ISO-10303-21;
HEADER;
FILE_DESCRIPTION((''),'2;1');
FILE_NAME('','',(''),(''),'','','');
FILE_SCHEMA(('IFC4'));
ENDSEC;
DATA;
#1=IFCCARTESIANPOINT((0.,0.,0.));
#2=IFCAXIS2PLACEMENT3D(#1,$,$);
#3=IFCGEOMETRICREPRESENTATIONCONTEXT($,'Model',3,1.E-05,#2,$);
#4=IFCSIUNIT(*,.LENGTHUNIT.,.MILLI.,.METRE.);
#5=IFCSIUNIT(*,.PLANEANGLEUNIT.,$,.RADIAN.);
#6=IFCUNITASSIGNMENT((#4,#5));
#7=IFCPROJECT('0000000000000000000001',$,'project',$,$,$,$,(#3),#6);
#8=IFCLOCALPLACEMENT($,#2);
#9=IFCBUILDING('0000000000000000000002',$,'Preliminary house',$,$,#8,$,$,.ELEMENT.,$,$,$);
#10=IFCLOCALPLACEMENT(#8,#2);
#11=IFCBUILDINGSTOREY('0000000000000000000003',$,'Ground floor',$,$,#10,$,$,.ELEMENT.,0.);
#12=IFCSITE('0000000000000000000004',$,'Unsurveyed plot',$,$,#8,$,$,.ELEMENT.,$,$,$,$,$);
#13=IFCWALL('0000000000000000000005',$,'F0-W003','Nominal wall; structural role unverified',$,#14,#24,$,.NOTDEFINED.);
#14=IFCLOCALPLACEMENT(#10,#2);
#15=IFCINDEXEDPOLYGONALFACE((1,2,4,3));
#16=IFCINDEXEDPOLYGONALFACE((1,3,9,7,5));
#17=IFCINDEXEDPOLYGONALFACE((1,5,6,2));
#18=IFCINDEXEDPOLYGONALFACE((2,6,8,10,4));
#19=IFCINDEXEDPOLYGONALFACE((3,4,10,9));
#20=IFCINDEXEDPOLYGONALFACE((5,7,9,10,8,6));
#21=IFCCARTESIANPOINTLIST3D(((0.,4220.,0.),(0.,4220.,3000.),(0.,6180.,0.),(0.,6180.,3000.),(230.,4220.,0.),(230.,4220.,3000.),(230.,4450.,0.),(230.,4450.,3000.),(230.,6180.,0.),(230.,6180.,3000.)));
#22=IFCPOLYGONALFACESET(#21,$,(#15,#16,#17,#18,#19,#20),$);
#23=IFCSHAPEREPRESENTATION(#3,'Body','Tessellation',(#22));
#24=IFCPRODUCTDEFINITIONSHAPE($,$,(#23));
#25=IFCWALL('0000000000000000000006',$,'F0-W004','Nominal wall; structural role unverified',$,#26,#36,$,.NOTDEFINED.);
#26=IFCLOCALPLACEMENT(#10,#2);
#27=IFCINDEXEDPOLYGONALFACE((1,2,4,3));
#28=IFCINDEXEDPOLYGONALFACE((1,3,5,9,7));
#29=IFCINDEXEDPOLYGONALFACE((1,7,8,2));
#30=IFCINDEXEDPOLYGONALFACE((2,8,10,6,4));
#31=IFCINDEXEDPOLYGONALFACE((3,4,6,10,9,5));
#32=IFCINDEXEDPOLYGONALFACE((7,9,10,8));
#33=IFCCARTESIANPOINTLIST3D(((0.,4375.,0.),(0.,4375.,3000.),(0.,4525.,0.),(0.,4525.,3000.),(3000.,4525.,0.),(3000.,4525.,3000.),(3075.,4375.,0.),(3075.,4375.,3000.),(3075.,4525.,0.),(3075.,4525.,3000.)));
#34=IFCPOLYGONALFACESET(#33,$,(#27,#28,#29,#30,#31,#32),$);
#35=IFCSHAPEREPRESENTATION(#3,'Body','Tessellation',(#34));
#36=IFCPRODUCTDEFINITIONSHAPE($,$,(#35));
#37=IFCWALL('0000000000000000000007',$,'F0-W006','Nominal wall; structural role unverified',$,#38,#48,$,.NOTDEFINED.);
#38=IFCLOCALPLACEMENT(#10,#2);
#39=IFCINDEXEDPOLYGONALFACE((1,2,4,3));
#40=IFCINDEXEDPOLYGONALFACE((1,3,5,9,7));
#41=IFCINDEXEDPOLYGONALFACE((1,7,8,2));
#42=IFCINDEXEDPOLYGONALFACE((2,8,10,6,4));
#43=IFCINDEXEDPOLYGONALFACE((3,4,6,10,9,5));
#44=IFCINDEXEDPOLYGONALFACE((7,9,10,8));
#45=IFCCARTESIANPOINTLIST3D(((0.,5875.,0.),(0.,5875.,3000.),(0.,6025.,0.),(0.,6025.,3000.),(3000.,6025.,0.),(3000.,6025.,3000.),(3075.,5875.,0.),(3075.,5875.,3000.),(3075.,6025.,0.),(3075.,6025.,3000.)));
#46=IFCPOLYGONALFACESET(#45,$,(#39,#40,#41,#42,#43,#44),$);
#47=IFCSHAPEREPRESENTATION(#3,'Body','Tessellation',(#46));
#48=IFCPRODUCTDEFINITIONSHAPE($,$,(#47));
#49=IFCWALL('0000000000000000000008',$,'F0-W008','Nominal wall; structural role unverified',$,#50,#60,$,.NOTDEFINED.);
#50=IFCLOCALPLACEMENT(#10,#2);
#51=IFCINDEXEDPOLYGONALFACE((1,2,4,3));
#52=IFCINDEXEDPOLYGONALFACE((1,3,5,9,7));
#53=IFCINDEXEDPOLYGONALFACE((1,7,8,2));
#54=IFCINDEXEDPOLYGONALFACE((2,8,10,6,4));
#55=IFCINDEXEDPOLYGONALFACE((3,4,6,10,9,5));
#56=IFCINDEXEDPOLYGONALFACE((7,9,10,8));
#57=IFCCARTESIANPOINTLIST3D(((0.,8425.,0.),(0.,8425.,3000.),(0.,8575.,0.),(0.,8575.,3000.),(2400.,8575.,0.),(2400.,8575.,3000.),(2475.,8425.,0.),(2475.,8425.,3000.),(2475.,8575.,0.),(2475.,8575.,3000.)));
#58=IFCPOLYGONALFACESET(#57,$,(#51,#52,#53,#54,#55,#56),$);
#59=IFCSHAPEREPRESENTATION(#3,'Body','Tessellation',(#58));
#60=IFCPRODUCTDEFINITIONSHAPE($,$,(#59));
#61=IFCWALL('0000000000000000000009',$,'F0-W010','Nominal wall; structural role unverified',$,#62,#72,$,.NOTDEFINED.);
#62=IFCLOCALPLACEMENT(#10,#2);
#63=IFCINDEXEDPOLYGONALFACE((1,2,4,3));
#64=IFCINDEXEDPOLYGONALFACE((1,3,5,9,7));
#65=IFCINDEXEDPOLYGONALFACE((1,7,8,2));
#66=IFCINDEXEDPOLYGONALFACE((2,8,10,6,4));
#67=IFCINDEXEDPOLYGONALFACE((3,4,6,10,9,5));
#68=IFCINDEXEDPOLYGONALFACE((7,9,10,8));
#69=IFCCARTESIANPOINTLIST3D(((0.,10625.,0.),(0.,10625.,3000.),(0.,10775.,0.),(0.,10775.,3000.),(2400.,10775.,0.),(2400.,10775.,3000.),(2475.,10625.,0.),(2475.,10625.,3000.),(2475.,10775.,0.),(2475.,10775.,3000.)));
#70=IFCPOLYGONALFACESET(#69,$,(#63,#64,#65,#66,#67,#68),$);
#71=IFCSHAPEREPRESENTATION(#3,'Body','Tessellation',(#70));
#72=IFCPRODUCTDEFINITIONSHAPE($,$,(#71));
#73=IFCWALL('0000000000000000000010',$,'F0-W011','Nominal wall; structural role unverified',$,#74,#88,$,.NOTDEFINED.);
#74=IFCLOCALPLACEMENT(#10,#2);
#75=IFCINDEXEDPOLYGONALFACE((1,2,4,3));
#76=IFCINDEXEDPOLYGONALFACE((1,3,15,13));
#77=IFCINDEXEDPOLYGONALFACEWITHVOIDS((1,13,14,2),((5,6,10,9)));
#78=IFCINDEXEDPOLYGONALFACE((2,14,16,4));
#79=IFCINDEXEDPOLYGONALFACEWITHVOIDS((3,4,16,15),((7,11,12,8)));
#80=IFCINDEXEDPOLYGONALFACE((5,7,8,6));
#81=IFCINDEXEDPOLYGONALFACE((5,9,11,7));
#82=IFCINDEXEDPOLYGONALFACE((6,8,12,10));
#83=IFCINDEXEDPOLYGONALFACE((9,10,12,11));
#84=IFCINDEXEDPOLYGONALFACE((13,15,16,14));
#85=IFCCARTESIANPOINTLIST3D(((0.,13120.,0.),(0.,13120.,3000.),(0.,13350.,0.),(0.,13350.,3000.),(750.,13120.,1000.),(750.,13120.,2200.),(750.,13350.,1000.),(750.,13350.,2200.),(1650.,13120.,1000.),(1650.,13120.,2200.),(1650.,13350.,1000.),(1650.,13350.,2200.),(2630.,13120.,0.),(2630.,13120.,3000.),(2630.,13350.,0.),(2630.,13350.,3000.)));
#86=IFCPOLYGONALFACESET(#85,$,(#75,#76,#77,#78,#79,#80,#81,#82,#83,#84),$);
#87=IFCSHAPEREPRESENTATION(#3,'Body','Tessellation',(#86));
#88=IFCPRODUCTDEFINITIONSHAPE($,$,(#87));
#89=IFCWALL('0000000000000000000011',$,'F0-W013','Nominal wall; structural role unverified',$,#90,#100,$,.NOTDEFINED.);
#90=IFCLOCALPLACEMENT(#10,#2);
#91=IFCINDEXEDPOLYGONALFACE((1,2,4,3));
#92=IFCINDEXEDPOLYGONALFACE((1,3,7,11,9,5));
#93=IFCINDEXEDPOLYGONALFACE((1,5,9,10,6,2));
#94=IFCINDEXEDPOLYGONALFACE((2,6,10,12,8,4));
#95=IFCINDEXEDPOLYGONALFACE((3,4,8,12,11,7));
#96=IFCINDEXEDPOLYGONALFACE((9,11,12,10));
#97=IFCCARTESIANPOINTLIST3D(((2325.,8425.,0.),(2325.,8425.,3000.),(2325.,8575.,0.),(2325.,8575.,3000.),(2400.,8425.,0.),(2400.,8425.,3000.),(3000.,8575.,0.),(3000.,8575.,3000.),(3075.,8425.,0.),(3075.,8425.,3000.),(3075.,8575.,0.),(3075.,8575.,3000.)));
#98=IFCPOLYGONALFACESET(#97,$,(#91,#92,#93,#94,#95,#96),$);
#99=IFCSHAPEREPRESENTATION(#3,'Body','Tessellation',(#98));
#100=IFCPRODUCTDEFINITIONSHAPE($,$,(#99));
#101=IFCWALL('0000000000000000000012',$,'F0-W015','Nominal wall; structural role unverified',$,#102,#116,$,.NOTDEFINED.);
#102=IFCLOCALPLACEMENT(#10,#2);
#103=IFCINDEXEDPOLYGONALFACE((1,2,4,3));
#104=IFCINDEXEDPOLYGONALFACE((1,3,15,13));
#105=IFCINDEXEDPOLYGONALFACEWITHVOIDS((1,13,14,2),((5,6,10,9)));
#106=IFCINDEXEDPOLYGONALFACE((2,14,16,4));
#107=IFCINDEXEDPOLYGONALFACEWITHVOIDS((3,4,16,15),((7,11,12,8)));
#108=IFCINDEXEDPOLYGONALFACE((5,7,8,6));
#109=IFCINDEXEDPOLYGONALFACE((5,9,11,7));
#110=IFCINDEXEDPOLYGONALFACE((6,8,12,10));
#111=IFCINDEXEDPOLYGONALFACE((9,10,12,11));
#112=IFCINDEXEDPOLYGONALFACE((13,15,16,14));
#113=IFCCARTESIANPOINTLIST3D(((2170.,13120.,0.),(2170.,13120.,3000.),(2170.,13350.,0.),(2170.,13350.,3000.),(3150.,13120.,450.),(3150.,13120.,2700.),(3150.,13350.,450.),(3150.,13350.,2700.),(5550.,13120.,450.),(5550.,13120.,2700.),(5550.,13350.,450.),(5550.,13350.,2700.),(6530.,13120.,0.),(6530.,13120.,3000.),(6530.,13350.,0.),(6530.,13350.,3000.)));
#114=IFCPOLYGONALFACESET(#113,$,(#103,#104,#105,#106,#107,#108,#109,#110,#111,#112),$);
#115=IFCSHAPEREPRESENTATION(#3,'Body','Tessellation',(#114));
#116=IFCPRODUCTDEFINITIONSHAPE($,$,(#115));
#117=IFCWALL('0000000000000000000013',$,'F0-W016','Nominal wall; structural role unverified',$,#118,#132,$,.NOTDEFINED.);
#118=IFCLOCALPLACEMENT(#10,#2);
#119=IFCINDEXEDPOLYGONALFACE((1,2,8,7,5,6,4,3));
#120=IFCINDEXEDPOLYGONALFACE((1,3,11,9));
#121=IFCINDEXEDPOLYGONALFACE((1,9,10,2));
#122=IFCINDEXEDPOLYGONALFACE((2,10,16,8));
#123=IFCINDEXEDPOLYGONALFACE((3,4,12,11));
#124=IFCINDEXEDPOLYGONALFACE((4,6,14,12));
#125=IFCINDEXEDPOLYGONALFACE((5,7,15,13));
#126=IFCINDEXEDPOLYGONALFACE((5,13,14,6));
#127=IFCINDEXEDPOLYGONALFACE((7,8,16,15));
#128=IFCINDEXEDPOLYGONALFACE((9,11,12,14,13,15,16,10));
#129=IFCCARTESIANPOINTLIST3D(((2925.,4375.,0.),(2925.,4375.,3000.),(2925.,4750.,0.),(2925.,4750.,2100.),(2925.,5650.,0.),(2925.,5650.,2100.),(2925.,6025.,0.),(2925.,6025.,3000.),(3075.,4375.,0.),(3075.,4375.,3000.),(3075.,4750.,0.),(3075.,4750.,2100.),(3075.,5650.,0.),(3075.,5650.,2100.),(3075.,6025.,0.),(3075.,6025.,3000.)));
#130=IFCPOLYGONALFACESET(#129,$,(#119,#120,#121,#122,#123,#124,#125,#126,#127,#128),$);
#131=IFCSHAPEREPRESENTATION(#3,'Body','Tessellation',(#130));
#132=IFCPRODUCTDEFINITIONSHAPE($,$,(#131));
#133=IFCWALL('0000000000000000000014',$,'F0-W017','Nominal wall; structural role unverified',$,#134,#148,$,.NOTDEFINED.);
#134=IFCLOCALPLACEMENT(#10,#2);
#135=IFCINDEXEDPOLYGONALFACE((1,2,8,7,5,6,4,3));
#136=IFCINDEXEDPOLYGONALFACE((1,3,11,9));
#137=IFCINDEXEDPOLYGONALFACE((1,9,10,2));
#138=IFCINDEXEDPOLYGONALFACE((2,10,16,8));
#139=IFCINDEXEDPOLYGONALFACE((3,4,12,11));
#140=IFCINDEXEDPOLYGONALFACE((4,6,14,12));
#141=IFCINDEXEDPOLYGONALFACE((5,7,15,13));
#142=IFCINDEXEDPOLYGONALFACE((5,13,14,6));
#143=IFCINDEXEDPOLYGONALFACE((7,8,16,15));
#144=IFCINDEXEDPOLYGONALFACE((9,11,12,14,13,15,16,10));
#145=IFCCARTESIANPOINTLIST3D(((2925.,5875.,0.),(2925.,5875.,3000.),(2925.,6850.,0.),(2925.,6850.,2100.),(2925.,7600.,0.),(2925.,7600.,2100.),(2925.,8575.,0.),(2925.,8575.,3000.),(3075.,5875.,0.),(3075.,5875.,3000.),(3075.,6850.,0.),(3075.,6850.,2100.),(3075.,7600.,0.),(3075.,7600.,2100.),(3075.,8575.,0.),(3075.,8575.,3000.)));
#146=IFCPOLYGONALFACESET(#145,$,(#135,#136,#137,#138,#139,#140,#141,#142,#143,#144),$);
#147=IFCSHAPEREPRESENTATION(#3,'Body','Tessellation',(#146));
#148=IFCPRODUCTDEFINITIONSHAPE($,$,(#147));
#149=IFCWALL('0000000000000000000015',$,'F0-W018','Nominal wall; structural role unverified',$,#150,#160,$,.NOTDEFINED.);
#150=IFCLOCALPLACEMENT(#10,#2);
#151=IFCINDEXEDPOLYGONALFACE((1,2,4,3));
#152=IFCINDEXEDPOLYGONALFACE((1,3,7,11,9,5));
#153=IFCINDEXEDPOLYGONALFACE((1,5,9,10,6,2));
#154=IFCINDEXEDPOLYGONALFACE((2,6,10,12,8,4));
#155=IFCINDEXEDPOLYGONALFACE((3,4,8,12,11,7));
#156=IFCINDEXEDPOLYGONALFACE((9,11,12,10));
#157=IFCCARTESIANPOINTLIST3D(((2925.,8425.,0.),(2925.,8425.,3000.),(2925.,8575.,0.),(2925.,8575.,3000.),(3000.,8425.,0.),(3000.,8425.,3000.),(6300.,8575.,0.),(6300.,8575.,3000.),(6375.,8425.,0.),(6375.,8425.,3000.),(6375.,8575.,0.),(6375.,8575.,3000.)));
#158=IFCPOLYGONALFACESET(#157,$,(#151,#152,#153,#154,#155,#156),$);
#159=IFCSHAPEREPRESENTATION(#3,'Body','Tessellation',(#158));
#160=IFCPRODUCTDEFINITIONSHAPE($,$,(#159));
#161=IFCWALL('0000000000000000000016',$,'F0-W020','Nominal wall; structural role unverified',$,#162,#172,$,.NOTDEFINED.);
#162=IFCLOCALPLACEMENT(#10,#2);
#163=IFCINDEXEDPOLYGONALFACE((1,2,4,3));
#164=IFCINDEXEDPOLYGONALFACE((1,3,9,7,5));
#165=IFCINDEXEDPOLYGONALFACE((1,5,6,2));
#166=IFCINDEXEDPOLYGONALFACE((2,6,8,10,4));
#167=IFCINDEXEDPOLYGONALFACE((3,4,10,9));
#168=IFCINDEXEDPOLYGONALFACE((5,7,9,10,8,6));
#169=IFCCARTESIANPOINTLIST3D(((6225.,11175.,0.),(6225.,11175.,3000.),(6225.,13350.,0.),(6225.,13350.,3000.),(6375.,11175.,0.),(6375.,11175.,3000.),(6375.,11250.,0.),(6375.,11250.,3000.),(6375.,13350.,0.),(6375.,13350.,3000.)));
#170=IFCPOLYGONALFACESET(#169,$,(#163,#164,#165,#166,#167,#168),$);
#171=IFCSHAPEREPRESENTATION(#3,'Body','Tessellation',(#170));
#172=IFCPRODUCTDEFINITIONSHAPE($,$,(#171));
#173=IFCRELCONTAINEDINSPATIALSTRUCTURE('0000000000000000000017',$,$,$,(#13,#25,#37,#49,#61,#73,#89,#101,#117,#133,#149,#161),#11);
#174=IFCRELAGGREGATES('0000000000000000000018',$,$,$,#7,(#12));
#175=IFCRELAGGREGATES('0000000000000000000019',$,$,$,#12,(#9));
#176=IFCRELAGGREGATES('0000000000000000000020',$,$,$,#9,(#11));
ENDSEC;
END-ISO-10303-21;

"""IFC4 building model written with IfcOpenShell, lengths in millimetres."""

from ifc_helpers import new_model, si_unit, frame, origin, place, context, project, spatial, polyline, outline, extrude, element, save


model = new_model("IFC4")

# Units and contexts
model_context = context("Model", 3, precision=1e-05, world=origin())
ifc_project = project(units=[si_unit("LENGTHUNIT", "METRE", prefix="MILLI"), si_unit("PLANEANGLEUNIT", "RADIAN")], contexts=[model_context])

# Site, building, storey
placement_1 = place(None, origin())
site = spatial("IfcSite", under=ifc_project, at=placement_1, Name="Unsurveyed plot", CompositionType="ELEMENT")
building = spatial("IfcBuilding", under=site, at=placement_1, Name="Preliminary house", CompositionType="ELEMENT")
placement_2 = place(placement_1, origin())
storey = spatial("IfcBuildingStorey", under=building, at=placement_2, Name="Ground floor", CompositionType="ELEMENT", Elevation=0.0)

# Walls
element("IfcWall", 1, at=placement_2, inside=storey, Name="F0-W003", Description="Nominal wall; structural role unverified", PredefinedType="NOTDEFINED", context=model_context, shape_type="SweptSolid", body=[
    extrude(outline(polyline([(230.0, 6180.0), (230.0, 4450.0), (230.0, 4220.0), (0.0, 4220.0), (0.0, 6180.0), (230.0, 6180.0)])), origin(), (0.0, 0.0, 1.0), 3000.0),
])
element("IfcWall", 2, at=placement_2, inside=storey, Name="F0-W004", Description="Nominal wall; structural role unverified", PredefinedType="NOTDEFINED", context=model_context, shape_type="SweptSolid", body=[
    extrude(outline(polyline([(3075.0, 4525.0), (3075.0, 4375.0), (0.0, 4375.0), (0.0, 4525.0), (3000.0, 4525.0), (3075.0, 4525.0)])), origin(), (0.0, 0.0, 1.0), 3000.0),
])

# Wall
element("IfcWall", 3, at=placement_2, inside=storey, Name="F0-W006", Description="Nominal wall; structural role unverified", PredefinedType="NOTDEFINED", context=model_context, shape_type="SweptSolid", body=[
    extrude(outline(polyline([(3075.0, 6025.0), (3075.0, 5875.0), (0.0, 5875.0), (0.0, 6025.0), (3000.0, 6025.0), (3075.0, 6025.0)])), origin(), (0.0, 0.0, 1.0), 3000.0),
])

# Wall
element("IfcWall", 4, at=placement_2, inside=storey, Name="F0-W008", Description="Nominal wall; structural role unverified", PredefinedType="NOTDEFINED", context=model_context, shape_type="SweptSolid", body=[
    extrude(outline(polyline([(2475.0, 8575.0), (2475.0, 8425.0), (0.0, 8425.0), (0.0, 8575.0), (2400.0, 8575.0), (2475.0, 8575.0)])), origin(), (0.0, 0.0, 1.0), 3000.0),
])

# Wall
element("IfcWall", 5, at=placement_2, inside=storey, Name="F0-W010", Description="Nominal wall; structural role unverified", PredefinedType="NOTDEFINED", context=model_context, shape_type="SweptSolid", body=[
    extrude(outline(polyline([(2475.0, 10775.0), (2475.0, 10625.0), (0.0, 10625.0), (0.0, 10775.0), (2400.0, 10775.0), (2475.0, 10775.0)])), origin(), (0.0, 0.0, 1.0), 3000.0),
])

# Wall, opening
wall_1 = element("IfcWall", 6, at=placement_2, inside=storey, Name="F0-W011", Description="Nominal wall; structural role unverified", PredefinedType="NOTDEFINED", context=model_context, shape_type="SweptSolid", body=[
    extrude(outline(polyline([(2630.0, 13120.0), (0.0, 13120.0), (0.0, 13350.0), (2630.0, 13350.0), (2630.0, 13120.0)])), origin(), (0.0, 0.0, 1.0), 3000.0),
])
element("IfcOpeningElement", 7, at=placement_2, cuts=wall_1, PredefinedType="OPENING", context=model_context, shape_type="SweptSolid", body=[
    extrude(outline(polyline([(750.0, 12705.0), (1650.0, 12705.0), (1650.0, 13765.0), (750.0, 13765.0), (750.0, 12705.0)])), frame((0.0, 0.0, 1000.0)), (0.0, 0.0, 1.0), 1200.0),
])

# Wall
element("IfcWall", 8, at=placement_2, inside=storey, Name="F0-W013", Description="Nominal wall; structural role unverified", PredefinedType="NOTDEFINED", context=model_context, shape_type="SweptSolid", body=[
    extrude(outline(polyline([(3075.0, 8575.0), (3075.0, 8425.0), (2400.0, 8425.0), (2325.0, 8425.0), (2325.0, 8575.0), (3000.0, 8575.0), (3075.0, 8575.0)])), origin(), (0.0, 0.0, 1.0), 3000.0),
])

# Walls, openings
wall_2 = element("IfcWall", 9, at=placement_2, inside=storey, Name="F0-W015", Description="Nominal wall; structural role unverified", PredefinedType="NOTDEFINED", context=model_context, shape_type="SweptSolid", body=[
    extrude(outline(polyline([(6530.0, 13120.0), (2400.0, 13120.0), (2170.0, 13120.0), (2170.0, 13350.0), (6530.0, 13350.0), (6530.0, 13120.0)])), origin(), (0.0, 0.0, 1.0), 3000.0),
])
element("IfcOpeningElement", 10, at=placement_2, cuts=wall_2, PredefinedType="OPENING", context=model_context, shape_type="SweptSolid", body=[
    extrude(outline(polyline([(3150.0, 12705.0), (5550.0, 12705.0), (5550.0, 13765.0), (3150.0, 13765.0), (3150.0, 12705.0)])), frame((0.0, 0.0, 450.0)), (0.0, 0.0, 1.0), 2250.0),
])
wall_3 = element("IfcWall", 11, at=placement_2, inside=storey, Name="F0-W016", Description="Nominal wall; structural role unverified", PredefinedType="NOTDEFINED", context=model_context, shape_type="SweptSolid", body=[
    extrude(outline(polyline([(2925.0, 6025.0), (3075.0, 6025.0), (3075.0, 4450.0), (3075.0, 4375.0), (2925.0, 4375.0), (2925.0, 5950.0), (2925.0, 6025.0)])), origin(), (0.0, 0.0, 1.0), 3000.0),
])
element("IfcOpeningElement", 12, at=placement_2, cuts=wall_3, PredefinedType="OPENING", context=model_context, shape_type="SweptSolid", body=[
    extrude(outline(polyline([(3450.0, 4750.0), (3450.0, 5650.0), (2550.0, 5650.0), (2550.0, 4750.0), (3450.0, 4750.0)])), origin(), (0.0, 0.0, 1.0), 2100.0),
])
wall_4 = element("IfcWall", 13, at=placement_2, inside=storey, Name="F0-W017", Description="Nominal wall; structural role unverified", PredefinedType="NOTDEFINED", context=model_context, shape_type="SweptSolid", body=[
    extrude(outline(polyline([(2925.0, 8575.0), (3075.0, 8575.0), (3075.0, 5950.0), (3075.0, 5875.0), (2925.0, 5875.0), (2925.0, 8500.0), (2925.0, 8575.0)])), origin(), (0.0, 0.0, 1.0), 3000.0),
])
element("IfcOpeningElement", 14, at=placement_2, cuts=wall_4, PredefinedType="OPENING", context=model_context, shape_type="SweptSolid", body=[
    extrude(outline(polyline([(3450.0, 6850.0), (3450.0, 7600.0), (2550.0, 7600.0), (2550.0, 6850.0), (3450.0, 6850.0)])), origin(), (0.0, 0.0, 1.0), 2100.0),
])

# Wall
element("IfcWall", 15, at=placement_2, inside=storey, Name="F0-W018", Description="Nominal wall; structural role unverified", PredefinedType="NOTDEFINED", context=model_context, shape_type="SweptSolid", body=[
    extrude(outline(polyline([(6375.0, 8575.0), (6375.0, 8425.0), (3000.0, 8425.0), (2925.0, 8425.0), (2925.0, 8575.0), (6300.0, 8575.0), (6375.0, 8575.0)])), origin(), (0.0, 0.0, 1.0), 3000.0),
])

# Wall
element("IfcWall", 16, at=placement_2, inside=storey, Name="F0-W020", Description="Nominal wall; structural role unverified", PredefinedType="NOTDEFINED", context=model_context, shape_type="SweptSolid", body=[
    extrude(outline(polyline([(6375.0, 11250.0), (6375.0, 11175.0), (6225.0, 11175.0), (6225.0, 13350.0), (6375.0, 13350.0), (6375.0, 11250.0)])), origin(), (0.0, 0.0, 1.0), 3000.0),
])

save(model, "model.ifc")
